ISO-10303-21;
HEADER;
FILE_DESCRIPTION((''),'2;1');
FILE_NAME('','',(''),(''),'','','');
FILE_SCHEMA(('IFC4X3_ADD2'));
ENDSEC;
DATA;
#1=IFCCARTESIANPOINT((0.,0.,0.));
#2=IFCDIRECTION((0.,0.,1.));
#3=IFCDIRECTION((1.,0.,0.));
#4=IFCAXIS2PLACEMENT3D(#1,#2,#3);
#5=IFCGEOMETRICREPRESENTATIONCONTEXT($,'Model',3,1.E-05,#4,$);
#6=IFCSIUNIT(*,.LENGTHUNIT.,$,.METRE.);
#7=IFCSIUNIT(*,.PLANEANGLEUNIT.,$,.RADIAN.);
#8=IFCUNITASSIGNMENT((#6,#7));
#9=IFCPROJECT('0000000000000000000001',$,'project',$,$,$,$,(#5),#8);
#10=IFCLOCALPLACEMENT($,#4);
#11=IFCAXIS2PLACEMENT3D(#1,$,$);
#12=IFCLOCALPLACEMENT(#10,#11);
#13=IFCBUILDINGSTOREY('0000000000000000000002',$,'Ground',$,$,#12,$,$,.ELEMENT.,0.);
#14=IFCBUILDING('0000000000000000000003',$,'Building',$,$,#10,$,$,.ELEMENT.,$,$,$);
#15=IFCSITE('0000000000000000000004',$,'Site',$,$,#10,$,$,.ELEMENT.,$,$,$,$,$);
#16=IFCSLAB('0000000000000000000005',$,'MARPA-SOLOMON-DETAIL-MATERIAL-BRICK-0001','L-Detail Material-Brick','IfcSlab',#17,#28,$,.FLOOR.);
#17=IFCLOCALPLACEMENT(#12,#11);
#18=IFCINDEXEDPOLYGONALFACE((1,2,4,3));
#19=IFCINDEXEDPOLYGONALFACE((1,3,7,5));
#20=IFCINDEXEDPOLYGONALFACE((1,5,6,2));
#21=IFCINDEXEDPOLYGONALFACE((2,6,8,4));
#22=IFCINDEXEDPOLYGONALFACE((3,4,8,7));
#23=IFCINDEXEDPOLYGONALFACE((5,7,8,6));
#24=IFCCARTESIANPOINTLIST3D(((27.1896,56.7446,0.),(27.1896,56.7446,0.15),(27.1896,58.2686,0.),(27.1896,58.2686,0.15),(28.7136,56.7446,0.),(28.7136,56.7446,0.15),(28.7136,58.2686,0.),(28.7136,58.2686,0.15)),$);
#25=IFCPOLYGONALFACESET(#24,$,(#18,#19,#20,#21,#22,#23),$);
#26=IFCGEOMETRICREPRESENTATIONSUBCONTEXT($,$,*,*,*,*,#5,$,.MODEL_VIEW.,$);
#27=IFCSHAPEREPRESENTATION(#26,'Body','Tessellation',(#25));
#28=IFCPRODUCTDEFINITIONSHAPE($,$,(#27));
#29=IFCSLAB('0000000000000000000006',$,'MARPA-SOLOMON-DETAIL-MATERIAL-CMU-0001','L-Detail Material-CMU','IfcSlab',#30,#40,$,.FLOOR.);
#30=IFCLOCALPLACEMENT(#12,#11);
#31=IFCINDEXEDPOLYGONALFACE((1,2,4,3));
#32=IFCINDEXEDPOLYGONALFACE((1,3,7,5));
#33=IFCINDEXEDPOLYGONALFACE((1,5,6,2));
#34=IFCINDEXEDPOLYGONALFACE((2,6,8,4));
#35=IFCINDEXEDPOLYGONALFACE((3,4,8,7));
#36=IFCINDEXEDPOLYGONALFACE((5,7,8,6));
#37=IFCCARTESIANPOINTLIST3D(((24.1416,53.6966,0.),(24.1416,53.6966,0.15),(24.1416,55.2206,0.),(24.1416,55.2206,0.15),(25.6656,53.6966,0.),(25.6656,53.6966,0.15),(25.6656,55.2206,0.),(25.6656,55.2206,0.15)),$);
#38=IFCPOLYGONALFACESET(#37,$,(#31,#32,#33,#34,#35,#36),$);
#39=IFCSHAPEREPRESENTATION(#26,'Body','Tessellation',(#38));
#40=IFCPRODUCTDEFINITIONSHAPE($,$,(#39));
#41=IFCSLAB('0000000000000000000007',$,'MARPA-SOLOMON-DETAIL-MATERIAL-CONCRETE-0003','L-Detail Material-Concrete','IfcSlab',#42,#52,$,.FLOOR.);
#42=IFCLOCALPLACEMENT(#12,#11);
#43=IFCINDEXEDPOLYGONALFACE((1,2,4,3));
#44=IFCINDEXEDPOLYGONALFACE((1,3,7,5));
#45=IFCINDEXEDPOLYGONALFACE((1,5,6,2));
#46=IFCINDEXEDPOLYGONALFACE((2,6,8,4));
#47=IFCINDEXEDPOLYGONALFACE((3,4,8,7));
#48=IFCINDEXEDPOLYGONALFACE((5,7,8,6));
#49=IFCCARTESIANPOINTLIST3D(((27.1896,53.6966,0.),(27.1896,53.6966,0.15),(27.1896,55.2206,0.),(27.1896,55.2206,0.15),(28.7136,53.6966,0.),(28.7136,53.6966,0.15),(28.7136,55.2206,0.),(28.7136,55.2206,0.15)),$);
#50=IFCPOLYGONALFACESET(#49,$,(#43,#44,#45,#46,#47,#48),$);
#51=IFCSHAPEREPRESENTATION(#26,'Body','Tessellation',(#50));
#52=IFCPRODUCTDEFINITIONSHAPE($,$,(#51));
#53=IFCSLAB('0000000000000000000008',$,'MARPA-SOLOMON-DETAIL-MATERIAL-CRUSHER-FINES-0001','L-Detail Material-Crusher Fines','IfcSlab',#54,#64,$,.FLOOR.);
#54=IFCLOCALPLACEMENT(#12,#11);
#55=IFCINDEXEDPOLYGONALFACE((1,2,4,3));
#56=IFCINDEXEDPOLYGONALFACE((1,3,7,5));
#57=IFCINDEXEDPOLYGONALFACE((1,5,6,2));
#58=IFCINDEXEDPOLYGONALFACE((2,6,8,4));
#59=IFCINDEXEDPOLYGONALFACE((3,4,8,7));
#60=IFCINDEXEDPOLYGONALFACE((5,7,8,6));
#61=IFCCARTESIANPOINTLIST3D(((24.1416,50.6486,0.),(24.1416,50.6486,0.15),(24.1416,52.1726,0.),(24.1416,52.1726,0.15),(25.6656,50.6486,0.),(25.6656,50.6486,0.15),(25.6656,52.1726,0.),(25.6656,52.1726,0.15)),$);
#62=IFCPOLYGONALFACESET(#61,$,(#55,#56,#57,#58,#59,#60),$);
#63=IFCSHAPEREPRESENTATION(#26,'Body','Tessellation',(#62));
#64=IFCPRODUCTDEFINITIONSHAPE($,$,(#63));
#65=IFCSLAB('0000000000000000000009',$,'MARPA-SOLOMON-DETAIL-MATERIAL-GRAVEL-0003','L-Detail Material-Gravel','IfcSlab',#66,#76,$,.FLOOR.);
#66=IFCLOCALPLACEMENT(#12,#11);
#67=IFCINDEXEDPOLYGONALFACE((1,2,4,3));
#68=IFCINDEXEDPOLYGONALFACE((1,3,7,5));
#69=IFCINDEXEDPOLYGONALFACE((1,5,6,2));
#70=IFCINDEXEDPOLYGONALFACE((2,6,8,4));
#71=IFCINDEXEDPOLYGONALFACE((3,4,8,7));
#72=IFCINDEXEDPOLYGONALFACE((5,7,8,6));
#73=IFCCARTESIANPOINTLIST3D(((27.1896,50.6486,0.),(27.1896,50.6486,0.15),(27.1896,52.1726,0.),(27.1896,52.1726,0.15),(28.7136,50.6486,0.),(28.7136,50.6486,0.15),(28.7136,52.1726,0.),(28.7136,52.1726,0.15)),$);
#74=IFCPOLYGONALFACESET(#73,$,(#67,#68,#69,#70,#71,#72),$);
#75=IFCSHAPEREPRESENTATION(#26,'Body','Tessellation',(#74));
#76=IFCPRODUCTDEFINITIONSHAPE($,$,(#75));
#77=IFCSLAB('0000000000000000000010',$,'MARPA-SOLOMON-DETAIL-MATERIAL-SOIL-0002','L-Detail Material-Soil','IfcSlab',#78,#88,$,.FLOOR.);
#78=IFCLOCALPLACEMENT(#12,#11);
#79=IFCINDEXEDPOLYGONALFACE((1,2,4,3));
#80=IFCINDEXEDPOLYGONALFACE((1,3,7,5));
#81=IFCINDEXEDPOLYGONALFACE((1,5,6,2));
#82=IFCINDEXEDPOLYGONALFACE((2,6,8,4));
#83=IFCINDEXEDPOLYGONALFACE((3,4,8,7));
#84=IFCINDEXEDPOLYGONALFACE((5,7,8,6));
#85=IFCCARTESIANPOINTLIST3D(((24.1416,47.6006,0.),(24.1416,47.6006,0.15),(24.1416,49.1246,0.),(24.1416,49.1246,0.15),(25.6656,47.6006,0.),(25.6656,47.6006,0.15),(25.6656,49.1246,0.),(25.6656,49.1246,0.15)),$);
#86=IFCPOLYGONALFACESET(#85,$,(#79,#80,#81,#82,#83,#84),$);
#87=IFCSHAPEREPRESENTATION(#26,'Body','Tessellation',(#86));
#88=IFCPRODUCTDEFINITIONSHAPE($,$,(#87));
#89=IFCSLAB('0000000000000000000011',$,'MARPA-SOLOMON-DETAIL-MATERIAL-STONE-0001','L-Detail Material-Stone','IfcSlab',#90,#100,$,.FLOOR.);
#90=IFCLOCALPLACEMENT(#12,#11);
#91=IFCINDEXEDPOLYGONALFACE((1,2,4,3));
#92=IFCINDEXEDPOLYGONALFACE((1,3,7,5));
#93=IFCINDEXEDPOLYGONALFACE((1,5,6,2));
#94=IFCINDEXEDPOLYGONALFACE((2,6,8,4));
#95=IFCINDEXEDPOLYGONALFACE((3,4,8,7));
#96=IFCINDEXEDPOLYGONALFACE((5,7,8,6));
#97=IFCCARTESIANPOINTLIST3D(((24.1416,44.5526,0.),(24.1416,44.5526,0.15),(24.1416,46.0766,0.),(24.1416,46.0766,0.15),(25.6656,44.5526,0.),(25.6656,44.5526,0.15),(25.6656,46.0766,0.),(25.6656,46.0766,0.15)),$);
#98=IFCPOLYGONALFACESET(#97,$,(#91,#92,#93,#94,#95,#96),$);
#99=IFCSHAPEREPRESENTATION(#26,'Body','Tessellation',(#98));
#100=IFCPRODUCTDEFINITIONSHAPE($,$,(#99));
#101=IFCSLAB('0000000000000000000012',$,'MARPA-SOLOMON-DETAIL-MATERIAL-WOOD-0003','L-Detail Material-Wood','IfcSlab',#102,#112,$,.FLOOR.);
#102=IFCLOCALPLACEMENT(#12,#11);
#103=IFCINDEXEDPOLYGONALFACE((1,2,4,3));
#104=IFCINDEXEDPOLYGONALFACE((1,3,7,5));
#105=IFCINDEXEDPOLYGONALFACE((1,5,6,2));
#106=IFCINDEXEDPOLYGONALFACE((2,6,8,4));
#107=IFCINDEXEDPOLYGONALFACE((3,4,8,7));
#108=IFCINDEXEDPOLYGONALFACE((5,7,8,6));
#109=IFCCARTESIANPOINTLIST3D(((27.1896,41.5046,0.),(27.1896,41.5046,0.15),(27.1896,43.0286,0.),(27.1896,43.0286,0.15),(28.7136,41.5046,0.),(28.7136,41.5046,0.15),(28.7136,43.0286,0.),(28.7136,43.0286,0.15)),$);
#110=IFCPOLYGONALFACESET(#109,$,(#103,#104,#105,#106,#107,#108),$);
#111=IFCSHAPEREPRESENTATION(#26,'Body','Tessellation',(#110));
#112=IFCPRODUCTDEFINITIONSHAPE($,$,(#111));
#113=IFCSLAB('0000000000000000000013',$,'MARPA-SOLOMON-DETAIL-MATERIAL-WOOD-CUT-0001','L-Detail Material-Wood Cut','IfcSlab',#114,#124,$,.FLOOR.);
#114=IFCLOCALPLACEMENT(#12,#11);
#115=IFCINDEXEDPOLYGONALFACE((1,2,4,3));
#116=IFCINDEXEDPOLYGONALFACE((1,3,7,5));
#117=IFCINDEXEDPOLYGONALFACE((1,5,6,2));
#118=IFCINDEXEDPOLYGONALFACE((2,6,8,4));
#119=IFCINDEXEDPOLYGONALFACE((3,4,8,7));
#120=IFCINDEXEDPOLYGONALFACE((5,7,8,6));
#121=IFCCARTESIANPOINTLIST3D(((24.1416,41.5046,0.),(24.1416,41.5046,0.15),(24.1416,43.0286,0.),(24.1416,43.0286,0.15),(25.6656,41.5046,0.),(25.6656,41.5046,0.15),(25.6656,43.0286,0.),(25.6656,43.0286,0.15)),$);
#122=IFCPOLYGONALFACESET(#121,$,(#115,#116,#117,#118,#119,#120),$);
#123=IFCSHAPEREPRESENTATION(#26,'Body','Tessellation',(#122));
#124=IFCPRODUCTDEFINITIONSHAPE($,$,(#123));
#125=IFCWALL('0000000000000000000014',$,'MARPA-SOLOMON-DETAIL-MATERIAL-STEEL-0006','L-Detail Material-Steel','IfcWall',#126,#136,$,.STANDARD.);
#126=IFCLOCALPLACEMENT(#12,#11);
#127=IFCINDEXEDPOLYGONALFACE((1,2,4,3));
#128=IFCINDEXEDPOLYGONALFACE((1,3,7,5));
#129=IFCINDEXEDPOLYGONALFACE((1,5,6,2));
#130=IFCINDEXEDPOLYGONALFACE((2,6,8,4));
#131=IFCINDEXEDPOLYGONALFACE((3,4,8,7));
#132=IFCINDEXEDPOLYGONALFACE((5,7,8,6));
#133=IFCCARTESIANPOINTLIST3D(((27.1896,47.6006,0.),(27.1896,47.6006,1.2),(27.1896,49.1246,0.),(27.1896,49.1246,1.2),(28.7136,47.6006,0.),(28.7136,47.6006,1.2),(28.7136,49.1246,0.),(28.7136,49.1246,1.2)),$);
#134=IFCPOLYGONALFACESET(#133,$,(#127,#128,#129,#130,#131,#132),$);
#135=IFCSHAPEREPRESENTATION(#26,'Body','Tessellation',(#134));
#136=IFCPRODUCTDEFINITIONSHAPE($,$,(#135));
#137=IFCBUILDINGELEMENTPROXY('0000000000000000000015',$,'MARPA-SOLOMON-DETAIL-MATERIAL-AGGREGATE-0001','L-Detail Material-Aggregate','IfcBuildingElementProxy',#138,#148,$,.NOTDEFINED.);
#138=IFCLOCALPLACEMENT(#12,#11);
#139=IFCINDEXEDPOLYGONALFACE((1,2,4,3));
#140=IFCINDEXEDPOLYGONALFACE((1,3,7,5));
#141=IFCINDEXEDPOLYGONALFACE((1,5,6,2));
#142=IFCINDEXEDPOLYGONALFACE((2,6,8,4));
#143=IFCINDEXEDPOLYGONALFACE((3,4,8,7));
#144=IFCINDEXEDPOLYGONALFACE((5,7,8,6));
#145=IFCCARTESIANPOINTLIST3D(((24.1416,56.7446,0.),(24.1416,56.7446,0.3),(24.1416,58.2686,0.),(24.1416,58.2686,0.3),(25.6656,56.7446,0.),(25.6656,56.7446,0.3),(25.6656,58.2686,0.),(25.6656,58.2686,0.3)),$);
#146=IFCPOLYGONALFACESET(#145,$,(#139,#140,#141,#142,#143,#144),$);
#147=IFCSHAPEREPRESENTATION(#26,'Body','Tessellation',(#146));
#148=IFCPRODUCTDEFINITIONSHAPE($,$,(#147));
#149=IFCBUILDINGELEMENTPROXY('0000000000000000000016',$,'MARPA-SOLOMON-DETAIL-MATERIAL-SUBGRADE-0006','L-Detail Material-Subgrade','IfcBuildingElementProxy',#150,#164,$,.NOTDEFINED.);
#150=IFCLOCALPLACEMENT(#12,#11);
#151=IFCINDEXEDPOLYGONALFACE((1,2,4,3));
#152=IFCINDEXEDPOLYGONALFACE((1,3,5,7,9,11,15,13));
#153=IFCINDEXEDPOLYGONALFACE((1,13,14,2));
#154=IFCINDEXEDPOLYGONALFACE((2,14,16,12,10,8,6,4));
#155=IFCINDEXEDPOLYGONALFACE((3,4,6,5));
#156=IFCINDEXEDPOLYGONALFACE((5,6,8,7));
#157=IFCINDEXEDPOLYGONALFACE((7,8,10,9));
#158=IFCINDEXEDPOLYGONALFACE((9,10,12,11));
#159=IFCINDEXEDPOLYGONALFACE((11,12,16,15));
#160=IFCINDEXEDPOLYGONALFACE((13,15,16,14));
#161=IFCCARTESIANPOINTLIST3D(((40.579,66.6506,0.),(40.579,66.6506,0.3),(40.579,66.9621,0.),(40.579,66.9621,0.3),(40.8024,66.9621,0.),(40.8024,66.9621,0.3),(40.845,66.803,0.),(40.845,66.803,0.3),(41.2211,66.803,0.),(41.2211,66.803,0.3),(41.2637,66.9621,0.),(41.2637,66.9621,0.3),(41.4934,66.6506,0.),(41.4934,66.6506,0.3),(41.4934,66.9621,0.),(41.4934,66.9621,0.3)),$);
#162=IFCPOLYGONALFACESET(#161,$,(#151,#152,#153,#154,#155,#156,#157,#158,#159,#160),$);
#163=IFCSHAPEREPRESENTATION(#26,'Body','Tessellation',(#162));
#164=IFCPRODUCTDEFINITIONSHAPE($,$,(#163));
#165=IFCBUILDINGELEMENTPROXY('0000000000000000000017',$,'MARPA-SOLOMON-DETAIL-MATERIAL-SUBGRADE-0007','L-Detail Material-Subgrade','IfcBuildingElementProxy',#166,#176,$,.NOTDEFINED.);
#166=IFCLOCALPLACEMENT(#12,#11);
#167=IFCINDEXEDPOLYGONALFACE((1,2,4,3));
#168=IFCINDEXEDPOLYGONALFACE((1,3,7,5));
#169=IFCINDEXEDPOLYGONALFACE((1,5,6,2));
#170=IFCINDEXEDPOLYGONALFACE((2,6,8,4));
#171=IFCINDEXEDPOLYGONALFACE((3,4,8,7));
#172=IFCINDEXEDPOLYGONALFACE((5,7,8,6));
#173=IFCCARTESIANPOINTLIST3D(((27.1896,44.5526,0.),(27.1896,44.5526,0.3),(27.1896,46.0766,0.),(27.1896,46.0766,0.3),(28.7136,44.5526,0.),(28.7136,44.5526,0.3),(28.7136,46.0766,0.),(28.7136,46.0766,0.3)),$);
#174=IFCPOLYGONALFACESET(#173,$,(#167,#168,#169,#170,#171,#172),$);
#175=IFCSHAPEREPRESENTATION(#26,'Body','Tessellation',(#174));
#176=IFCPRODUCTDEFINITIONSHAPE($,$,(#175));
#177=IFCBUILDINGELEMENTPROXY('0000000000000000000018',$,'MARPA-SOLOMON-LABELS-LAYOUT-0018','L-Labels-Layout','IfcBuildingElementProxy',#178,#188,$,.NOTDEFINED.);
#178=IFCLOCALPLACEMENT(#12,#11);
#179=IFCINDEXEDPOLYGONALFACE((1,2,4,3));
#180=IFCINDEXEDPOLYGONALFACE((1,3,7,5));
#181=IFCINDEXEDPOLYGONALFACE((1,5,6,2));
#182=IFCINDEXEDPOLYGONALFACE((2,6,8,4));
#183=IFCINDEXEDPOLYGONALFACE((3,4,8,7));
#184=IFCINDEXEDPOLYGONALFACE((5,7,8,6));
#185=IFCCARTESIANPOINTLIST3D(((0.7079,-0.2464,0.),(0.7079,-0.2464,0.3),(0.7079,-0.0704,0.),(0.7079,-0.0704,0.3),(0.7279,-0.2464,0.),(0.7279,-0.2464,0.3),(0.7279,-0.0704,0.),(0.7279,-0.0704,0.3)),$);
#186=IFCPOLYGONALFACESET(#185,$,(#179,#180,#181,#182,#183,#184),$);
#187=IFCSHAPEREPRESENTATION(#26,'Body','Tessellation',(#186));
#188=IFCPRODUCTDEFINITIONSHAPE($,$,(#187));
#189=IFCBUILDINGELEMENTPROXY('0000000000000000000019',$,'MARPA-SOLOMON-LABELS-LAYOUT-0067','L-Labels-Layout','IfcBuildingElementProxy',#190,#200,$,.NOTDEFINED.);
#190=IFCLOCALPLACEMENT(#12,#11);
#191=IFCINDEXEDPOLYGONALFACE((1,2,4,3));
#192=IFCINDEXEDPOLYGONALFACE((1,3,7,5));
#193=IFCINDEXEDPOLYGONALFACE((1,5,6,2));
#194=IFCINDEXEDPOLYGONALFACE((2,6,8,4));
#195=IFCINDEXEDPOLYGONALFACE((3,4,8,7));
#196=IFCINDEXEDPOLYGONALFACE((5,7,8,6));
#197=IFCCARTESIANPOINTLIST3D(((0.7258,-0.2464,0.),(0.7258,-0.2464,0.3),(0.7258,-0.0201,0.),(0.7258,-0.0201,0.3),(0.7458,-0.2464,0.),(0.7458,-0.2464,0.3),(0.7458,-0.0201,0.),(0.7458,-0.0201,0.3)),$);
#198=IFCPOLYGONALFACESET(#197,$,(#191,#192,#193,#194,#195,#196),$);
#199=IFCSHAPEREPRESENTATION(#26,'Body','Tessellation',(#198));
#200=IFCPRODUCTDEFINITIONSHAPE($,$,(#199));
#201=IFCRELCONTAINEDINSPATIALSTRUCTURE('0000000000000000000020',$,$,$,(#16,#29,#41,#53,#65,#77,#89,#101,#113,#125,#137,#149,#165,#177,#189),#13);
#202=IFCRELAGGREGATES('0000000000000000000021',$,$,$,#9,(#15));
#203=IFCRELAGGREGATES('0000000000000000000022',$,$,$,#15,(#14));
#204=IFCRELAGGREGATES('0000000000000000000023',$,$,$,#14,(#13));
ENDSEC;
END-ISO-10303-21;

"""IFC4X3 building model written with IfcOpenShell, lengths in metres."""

from ifc_helpers import new_model, si_unit, frame, frame_2d, origin, origin_with_axes, place, context, subcontext, project, spatial, polyline, rectangle, outline, extrude, element, save


model = new_model("IFC4X3")

# Units and contexts
model_context = context("Model", 3, precision=1e-05, world=origin_with_axes())
sub_context = subcontext(model_context, None, None, "MODEL_VIEW")
ifc_project = project(units=[si_unit("LENGTHUNIT", "METRE"), si_unit("PLANEANGLEUNIT", "RADIAN")], contexts=[model_context])

# Site, building, storey
placement = place(None, origin_with_axes())
site = spatial("IfcSite", under=ifc_project, at=placement, Name="Site", CompositionType="ELEMENT")
building = spatial("IfcBuilding", under=site, at=placement, Name="Building", CompositionType="ELEMENT")
storey_placement = place(placement, origin())
storey = spatial("IfcBuildingStorey", under=building, at=storey_placement, Name="Ground", CompositionType="ELEMENT", Elevation=0.0)

# Slabs
slab_1_placement = place(storey_placement, frame((27.1896, 56.7446, 0.0)))
element("IfcSlab", 1, at=slab_1_placement, inside=storey, Name="MARPA-SOLOMON-DETAIL-MATERIAL-BRICK-0001", Description="L-Detail Material-Brick", ObjectType="IfcSlab", PredefinedType="FLOOR", context=sub_context, shape_type="SweptSolid", body=[
    extrude(outline(polyline([(0.0, 1.524), (1.524, 1.524), (1.524, 0.0), (0.0, 0.0), (0.0, 1.524)])), origin(), (0.0, 0.0, 1.0), 0.15),
])
slab_2_placement = place(storey_placement, frame((24.1416, 53.6966, 0.0)))
element("IfcSlab", 2, at=slab_2_placement, inside=storey, Name="MARPA-SOLOMON-DETAIL-MATERIAL-CMU-0001", Description="L-Detail Material-CMU", ObjectType="IfcSlab", PredefinedType="FLOOR", context=sub_context, shape_type="SweptSolid", body=[
    extrude(outline(polyline([(0.0, 1.524), (1.524, 1.524), (1.524, 0.0), (0.0, 0.0), (0.0, 1.524)])), origin(), (0.0, 0.0, 1.0), 0.15),
])
slab_3_placement = place(storey_placement, frame((27.1896, 53.6966, 0.0)))
element("IfcSlab", 3, at=slab_3_placement, inside=storey, Name="MARPA-SOLOMON-DETAIL-MATERIAL-CONCRETE-0003", Description="L-Detail Material-Concrete", ObjectType="IfcSlab", PredefinedType="FLOOR", context=sub_context, shape_type="SweptSolid", body=[
    extrude(outline(polyline([(0.0, 1.524), (1.524, 1.524), (1.524, 0.0), (0.0, 0.0), (0.0, 1.524)])), origin(), (0.0, 0.0, 1.0), 0.15),
])
slab_4_placement = place(storey_placement, frame((24.1416, 50.6486, 0.0)))
element("IfcSlab", 4, at=slab_4_placement, inside=storey, Name="MARPA-SOLOMON-DETAIL-MATERIAL-CRUSHER-FINES-0001", Description="L-Detail Material-Crusher Fines", ObjectType="IfcSlab", PredefinedType="FLOOR", context=sub_context, shape_type="SweptSolid", body=[
    extrude(outline(polyline([(0.0, 1.524), (1.524, 1.524), (1.524, 0.0), (0.0, 0.0), (0.0, 1.524)])), origin(), (0.0, 0.0, 1.0), 0.15),
])
slab_5_placement = place(storey_placement, frame((27.1896, 50.6486, 0.0)))
element("IfcSlab", 5, at=slab_5_placement, inside=storey, Name="MARPA-SOLOMON-DETAIL-MATERIAL-GRAVEL-0003", Description="L-Detail Material-Gravel", ObjectType="IfcSlab", PredefinedType="FLOOR", context=sub_context, shape_type="SweptSolid", body=[
    extrude(outline(polyline([(0.0, 1.524), (1.524, 1.524), (1.524, 0.0), (0.0, 0.0), (0.0, 1.524)])), origin(), (0.0, 0.0, 1.0), 0.15),
])
slab_6_placement = place(storey_placement, frame((24.1416, 47.6006, 0.0)))
element("IfcSlab", 6, at=slab_6_placement, inside=storey, Name="MARPA-SOLOMON-DETAIL-MATERIAL-SOIL-0002", Description="L-Detail Material-Soil", ObjectType="IfcSlab", PredefinedType="FLOOR", context=sub_context, shape_type="SweptSolid", body=[
    extrude(outline(polyline([(0.0, 1.524), (1.524, 1.524), (1.524, 0.0), (0.0, 0.0), (0.0, 1.524)])), origin(), (0.0, 0.0, 1.0), 0.15),
])
slab_7_placement = place(storey_placement, frame((24.1416, 44.5526, 0.0)))
element("IfcSlab", 7, at=slab_7_placement, inside=storey, Name="MARPA-SOLOMON-DETAIL-MATERIAL-STONE-0001", Description="L-Detail Material-Stone", ObjectType="IfcSlab", PredefinedType="FLOOR", context=sub_context, shape_type="SweptSolid", body=[
    extrude(outline(polyline([(0.0, 1.524), (1.524, 1.524), (1.524, 0.0), (0.0, 0.0), (0.0, 1.524)])), origin(), (0.0, 0.0, 1.0), 0.15),
])
slab_8_placement = place(storey_placement, frame((27.1896, 41.5046, 0.0)))
element("IfcSlab", 8, at=slab_8_placement, inside=storey, Name="MARPA-SOLOMON-DETAIL-MATERIAL-WOOD-0003", Description="L-Detail Material-Wood", ObjectType="IfcSlab", PredefinedType="FLOOR", context=sub_context, shape_type="SweptSolid", body=[
    extrude(outline(polyline([(0.0, 1.524), (1.524, 1.524), (1.524, 0.0), (0.0, 0.0), (0.0, 1.524)])), origin(), (0.0, 0.0, 1.0), 0.15),
])
slab_9_placement = place(storey_placement, frame((24.1416, 41.5046, 0.0)))
element("IfcSlab", 9, at=slab_9_placement, inside=storey, Name="MARPA-SOLOMON-DETAIL-MATERIAL-WOOD-CUT-0001", Description="L-Detail Material-Wood Cut", ObjectType="IfcSlab", PredefinedType="FLOOR", context=sub_context, shape_type="SweptSolid", body=[
    extrude(outline(polyline([(0.0, 1.524), (1.524, 1.524), (1.524, 0.0), (0.0, 0.0), (0.0, 1.524)])), origin(), (0.0, 0.0, 1.0), 0.15),
])

# Wall
wall_placement = place(storey_placement, frame((27.9516, 47.6006, 0.0), x_axis=(0.0, 1.0, 0.0)))
element("IfcWall", 10, at=wall_placement, inside=storey, Name="MARPA-SOLOMON-DETAIL-MATERIAL-STEEL-0006", Description="L-Detail Material-Steel", ObjectType="IfcWall", PredefinedType="STANDARD", context=sub_context, shape_type="SweptSolid", body=[
    extrude(rectangle(XDim=1.524, YDim=1.524, at=frame_2d((0.762, 0.0))), origin(), (0.0, 0.0, 1.0), 1.2),
])

# Building element proxies
proxy_1_placement = place(placement, frame((24.1416, 56.7446, 0.0)))
element("IfcBuildingElementProxy", 11, at=proxy_1_placement, inside=storey, Name="MARPA-SOLOMON-DETAIL-MATERIAL-AGGREGATE-0001", Description="L-Detail Material-Aggregate", ObjectType="IfcBuildingElementProxy", PredefinedType="NOTDEFINED", context=sub_context, shape_type="SweptSolid", body=[
    extrude(outline(polyline([(0.0, 1.524), (1.524, 1.524), (1.524, 0.0), (0.0, 0.0), (0.0, 1.524)])), origin(), (0.0, 0.0, 1.0), 0.3),
])
proxy_2_placement = place(placement, frame((40.579, 66.6506, 0.0)))
element("IfcBuildingElementProxy", 12, at=proxy_2_placement, inside=storey, Name="MARPA-SOLOMON-DETAIL-MATERIAL-SUBGRADE-0006", Description="L-Detail Material-Subgrade", ObjectType="IfcBuildingElementProxy", PredefinedType="NOTDEFINED", context=sub_context, shape_type="SweptSolid", body=[
    extrude(outline(polyline([(0.0, 0.0), (0.9144, 0.0), (0.9144, 0.3115), (0.6848, 0.3115), (0.6421, 0.1524), (0.2661, 0.1524), (0.2235, 0.3115), (0.0, 0.3115), (0.0, 0.0)])), origin(), (0.0, 0.0, 1.0), 0.3),
])
proxy_3_placement = place(placement, frame((27.1896, 44.5526, 0.0)))
element("IfcBuildingElementProxy", 13, at=proxy_3_placement, inside=storey, Name="MARPA-SOLOMON-DETAIL-MATERIAL-SUBGRADE-0007", Description="L-Detail Material-Subgrade", ObjectType="IfcBuildingElementProxy", PredefinedType="NOTDEFINED", context=sub_context, shape_type="SweptSolid", body=[
    extrude(outline(polyline([(0.0, 1.524), (1.524, 1.524), (1.524, 0.0), (0.0, 0.0), (0.0, 1.524)])), origin(), (0.0, 0.0, 1.0), 0.3),
])
for number, where, name in (
    (14, (0.7079, -0.2464, 0.0), "MARPA-SOLOMON-LABELS-LAYOUT-0018"),
):
    element("IfcBuildingElementProxy", number, at=place(placement, frame(where)), inside=storey, Name=name, Description="L-Labels-Layout", ObjectType="IfcBuildingElementProxy", PredefinedType="NOTDEFINED", context=sub_context, shape_type="SweptSolid", body=[
        extrude(rectangle(XDim=0.02, YDim=0.176, at=frame_2d((0.01, 0.088))), origin(), (0.0, 0.0, 1.0), 0.3),
    ])
for number, where, name in (
    (15, (0.7258, -0.2464, 0.0), "MARPA-SOLOMON-LABELS-LAYOUT-0067"),
):
    element("IfcBuildingElementProxy", number, at=place(placement, frame(where)), inside=storey, Name=name, Description="L-Labels-Layout", ObjectType="IfcBuildingElementProxy", PredefinedType="NOTDEFINED", context=sub_context, shape_type="SweptSolid", body=[
        extrude(rectangle(XDim=0.02, YDim=0.2263, at=frame_2d((0.01, 0.1132))), origin(), (0.0, 0.0, 1.0), 0.3),
    ])

save(model, "model.ifc")
